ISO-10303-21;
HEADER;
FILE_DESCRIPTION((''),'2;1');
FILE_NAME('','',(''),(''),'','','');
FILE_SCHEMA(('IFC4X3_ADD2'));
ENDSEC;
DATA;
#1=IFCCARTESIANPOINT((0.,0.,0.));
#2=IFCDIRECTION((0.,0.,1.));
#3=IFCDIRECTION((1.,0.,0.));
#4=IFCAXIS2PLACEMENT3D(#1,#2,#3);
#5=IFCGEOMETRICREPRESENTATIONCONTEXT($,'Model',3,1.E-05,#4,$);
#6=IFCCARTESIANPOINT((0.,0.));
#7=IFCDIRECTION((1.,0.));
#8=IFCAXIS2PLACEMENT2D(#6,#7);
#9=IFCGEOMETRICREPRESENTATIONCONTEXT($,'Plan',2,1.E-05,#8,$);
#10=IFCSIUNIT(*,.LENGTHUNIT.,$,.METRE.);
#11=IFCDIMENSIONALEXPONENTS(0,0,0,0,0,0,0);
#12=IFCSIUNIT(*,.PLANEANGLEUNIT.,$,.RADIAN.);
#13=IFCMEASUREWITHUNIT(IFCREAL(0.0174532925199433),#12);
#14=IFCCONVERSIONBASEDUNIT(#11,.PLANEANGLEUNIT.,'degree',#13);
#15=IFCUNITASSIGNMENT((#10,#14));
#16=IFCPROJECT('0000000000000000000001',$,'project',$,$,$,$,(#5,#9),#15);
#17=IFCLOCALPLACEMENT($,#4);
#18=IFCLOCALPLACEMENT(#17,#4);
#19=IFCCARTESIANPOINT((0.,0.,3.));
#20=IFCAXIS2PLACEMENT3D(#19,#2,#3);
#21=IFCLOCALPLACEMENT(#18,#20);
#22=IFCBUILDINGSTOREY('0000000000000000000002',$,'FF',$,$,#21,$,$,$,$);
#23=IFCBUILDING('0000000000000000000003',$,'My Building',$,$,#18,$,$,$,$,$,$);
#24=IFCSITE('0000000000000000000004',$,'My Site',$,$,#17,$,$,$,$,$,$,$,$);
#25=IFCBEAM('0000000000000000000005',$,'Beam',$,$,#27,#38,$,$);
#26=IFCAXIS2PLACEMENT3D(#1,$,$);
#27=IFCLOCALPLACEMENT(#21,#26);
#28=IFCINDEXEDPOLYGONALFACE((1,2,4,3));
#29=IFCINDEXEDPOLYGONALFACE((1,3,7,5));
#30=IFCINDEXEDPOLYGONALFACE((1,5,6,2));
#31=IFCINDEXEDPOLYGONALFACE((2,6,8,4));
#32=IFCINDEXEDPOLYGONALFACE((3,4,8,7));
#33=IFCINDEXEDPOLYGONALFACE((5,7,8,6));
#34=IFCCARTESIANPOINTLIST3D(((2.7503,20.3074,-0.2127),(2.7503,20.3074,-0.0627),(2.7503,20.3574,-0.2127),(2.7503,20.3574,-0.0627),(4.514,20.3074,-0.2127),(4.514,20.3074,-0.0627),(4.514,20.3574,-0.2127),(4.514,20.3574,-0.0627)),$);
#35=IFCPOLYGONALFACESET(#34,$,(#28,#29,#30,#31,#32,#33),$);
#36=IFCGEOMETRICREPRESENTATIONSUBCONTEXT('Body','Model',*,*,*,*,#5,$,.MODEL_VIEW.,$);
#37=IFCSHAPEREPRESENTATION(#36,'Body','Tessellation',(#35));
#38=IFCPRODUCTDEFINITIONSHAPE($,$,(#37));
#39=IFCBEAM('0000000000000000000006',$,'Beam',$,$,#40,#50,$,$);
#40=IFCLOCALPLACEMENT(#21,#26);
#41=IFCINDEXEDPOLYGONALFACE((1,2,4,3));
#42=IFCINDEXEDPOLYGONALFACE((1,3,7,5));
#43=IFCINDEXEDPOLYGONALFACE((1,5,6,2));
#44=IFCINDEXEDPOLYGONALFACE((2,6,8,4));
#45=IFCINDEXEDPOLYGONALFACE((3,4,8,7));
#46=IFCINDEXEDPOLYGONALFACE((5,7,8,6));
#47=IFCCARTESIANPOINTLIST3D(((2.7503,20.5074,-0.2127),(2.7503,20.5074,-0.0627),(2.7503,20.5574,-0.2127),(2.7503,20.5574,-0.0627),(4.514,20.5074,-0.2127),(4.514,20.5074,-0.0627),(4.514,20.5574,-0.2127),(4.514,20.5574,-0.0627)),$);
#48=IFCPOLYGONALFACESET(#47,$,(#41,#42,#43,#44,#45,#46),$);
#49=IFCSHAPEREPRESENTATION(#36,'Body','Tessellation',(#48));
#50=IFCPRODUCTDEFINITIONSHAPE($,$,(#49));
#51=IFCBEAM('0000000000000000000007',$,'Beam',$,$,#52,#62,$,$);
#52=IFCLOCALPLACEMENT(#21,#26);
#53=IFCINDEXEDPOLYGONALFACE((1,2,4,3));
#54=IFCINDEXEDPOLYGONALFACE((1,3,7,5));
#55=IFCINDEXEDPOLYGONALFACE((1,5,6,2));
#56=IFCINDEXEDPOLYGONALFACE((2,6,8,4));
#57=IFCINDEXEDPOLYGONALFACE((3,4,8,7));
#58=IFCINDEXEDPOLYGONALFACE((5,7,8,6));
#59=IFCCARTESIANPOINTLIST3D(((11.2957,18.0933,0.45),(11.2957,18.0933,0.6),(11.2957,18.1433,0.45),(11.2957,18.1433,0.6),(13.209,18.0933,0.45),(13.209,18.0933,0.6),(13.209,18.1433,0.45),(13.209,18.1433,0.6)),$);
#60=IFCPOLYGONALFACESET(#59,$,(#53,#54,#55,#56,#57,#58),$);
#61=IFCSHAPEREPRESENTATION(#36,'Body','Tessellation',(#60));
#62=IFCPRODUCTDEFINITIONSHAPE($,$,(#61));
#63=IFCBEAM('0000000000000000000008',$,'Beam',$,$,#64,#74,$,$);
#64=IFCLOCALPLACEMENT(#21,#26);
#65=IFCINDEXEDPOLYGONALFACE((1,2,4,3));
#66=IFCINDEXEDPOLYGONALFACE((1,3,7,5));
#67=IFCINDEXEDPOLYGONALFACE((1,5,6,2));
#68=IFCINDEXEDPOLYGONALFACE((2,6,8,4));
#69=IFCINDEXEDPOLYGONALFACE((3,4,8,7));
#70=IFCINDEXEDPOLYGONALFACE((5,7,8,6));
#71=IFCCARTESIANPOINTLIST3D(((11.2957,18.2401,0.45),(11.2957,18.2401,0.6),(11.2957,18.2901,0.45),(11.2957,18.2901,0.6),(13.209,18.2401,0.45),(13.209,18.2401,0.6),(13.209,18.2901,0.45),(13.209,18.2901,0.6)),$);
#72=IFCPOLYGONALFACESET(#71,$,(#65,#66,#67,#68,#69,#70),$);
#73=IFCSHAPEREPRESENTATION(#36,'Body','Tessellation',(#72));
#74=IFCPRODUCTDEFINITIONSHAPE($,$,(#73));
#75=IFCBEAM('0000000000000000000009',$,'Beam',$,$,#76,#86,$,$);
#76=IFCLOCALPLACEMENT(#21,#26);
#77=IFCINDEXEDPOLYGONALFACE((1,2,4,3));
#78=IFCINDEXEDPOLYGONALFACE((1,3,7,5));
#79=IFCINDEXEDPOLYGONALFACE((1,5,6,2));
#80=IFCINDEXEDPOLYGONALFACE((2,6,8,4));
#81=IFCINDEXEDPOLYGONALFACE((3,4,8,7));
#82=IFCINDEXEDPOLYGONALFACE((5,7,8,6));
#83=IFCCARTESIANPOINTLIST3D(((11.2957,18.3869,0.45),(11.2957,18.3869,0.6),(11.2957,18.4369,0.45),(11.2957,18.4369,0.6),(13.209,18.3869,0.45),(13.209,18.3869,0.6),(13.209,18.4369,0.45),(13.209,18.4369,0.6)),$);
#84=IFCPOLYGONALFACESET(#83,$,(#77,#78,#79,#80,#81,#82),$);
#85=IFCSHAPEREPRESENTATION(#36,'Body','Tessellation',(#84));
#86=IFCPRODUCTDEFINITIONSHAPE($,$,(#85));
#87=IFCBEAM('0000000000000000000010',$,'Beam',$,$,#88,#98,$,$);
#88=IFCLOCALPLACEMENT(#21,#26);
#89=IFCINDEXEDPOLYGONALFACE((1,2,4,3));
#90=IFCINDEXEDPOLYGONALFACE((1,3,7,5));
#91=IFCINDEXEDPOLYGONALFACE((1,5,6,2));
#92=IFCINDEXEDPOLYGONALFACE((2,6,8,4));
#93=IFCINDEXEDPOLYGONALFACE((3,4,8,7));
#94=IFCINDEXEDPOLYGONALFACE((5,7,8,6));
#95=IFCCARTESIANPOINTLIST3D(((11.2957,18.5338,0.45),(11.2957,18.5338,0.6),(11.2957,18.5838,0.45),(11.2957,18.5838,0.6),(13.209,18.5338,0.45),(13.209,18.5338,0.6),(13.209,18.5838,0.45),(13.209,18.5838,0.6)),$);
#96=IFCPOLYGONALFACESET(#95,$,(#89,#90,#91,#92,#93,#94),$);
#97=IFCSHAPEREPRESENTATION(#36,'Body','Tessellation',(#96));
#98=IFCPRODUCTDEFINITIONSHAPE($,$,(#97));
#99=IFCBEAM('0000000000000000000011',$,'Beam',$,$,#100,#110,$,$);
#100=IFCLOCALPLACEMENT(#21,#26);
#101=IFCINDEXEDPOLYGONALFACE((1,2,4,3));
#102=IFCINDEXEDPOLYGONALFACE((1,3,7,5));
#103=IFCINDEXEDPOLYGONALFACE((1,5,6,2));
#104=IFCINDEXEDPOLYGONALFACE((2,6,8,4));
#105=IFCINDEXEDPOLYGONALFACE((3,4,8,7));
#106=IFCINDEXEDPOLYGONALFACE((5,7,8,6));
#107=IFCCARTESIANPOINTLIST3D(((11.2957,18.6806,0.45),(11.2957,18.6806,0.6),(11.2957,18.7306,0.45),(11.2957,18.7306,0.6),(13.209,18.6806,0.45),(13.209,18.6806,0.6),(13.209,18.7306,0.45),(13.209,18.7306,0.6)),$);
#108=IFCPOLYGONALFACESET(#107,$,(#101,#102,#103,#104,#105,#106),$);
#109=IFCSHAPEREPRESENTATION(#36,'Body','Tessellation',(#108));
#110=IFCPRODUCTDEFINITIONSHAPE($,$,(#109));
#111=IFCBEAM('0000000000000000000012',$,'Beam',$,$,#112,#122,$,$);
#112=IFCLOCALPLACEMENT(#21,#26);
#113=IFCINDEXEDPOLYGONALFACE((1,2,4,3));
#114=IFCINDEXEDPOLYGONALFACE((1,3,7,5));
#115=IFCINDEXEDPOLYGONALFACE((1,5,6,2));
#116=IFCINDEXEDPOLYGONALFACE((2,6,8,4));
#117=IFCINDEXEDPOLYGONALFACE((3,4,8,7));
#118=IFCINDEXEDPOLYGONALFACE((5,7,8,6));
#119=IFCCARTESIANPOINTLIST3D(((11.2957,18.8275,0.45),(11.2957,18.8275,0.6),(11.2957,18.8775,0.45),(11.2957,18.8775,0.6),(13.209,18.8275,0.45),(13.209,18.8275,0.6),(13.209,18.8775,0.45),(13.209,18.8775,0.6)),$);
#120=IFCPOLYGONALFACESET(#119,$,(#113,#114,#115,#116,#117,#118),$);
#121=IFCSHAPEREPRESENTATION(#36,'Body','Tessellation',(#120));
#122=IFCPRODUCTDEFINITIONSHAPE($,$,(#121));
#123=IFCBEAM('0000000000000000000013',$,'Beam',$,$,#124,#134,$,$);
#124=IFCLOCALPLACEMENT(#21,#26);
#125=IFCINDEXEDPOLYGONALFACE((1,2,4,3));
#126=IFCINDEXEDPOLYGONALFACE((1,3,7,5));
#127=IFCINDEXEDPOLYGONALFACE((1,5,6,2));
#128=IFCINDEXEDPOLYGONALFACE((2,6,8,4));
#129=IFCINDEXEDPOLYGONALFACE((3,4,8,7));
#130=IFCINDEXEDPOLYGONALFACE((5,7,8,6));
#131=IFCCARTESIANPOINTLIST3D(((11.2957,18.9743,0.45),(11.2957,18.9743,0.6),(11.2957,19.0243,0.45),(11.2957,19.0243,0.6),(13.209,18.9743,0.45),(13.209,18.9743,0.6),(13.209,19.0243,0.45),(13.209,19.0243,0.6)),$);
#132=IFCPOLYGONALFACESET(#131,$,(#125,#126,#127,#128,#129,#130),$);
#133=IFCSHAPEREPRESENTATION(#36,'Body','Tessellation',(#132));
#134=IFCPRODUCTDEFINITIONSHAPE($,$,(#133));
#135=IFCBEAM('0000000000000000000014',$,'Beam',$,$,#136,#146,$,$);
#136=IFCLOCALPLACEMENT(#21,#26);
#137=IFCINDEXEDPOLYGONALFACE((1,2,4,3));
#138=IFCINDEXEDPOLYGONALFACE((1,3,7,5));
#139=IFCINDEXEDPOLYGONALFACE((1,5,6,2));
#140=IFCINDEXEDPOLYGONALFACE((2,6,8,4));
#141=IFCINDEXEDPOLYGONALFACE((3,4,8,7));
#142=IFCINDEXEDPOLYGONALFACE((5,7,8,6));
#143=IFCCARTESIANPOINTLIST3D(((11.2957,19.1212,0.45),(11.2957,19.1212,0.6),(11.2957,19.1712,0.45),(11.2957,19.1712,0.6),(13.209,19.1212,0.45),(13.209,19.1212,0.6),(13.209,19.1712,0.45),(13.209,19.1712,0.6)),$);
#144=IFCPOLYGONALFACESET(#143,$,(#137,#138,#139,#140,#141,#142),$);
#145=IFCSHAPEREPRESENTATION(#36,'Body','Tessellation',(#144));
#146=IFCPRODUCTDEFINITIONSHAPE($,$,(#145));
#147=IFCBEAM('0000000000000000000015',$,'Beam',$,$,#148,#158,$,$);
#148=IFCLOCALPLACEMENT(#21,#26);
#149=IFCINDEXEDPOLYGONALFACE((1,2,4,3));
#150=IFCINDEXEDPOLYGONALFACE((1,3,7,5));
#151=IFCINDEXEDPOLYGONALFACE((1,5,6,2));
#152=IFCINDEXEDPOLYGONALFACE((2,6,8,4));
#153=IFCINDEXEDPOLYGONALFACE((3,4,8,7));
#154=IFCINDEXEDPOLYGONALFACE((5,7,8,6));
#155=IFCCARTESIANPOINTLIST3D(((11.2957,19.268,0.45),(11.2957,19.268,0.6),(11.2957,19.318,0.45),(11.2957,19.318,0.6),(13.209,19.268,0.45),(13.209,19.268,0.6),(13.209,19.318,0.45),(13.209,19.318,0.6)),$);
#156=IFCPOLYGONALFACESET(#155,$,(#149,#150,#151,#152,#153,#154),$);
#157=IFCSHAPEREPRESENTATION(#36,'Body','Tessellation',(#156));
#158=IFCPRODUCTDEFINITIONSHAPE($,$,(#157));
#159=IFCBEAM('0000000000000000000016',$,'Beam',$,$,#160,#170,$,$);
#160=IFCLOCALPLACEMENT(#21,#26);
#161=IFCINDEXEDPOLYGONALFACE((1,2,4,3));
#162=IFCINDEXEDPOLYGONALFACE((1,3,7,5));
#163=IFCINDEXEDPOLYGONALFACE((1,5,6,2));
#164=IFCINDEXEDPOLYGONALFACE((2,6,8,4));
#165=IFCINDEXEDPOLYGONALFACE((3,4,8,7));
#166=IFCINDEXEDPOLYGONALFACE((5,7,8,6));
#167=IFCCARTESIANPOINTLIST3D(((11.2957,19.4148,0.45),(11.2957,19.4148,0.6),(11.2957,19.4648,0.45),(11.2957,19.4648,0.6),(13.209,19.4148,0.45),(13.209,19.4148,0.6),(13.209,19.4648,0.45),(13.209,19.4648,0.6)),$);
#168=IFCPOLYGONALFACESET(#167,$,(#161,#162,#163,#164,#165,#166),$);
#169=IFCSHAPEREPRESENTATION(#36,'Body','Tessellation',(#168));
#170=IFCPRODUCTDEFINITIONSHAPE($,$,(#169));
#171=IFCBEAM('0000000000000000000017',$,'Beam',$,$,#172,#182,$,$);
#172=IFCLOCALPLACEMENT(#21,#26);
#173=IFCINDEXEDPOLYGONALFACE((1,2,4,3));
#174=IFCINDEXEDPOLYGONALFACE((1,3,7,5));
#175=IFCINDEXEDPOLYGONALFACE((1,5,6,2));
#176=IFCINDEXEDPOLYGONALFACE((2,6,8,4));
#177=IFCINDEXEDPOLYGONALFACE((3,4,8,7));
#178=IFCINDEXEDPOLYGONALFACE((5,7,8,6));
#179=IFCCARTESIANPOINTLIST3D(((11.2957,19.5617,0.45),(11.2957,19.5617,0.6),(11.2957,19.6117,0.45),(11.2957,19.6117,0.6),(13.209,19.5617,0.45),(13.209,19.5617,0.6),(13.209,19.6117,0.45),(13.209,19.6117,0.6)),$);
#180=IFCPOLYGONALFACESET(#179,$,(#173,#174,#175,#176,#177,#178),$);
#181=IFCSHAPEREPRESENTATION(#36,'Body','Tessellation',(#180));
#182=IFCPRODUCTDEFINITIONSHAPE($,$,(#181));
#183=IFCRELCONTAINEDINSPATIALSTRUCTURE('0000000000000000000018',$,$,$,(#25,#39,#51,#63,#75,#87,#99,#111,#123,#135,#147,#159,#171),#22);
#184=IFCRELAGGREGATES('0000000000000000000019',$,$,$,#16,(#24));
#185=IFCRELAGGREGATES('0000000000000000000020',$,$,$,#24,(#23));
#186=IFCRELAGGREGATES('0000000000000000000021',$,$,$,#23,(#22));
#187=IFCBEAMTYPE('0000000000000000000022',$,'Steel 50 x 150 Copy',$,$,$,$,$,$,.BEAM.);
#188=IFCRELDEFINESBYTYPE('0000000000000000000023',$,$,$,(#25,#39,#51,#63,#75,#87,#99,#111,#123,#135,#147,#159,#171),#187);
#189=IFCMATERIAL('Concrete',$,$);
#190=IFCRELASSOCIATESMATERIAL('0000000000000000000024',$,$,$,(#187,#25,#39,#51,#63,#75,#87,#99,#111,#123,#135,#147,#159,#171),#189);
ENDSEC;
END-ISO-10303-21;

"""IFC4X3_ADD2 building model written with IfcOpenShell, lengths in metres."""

from ifc_helpers import new_model, entity, si_unit, converted_unit, frame, origin_with_axes, origin_2d_with_axis, place, context, subcontext, project, spatial, rectangle, extrude, material, material_profile, profile_set, profile_usage, type_object, element, save


model = new_model("IFC4X3_ADD2")

# Units and contexts
model_context = context("Model", 3, precision=1e-05, world=origin_with_axes())
plan_context = context("Plan", 2, precision=1e-05, world=origin_2d_with_axis())
body_context = subcontext(model_context, "Body", "Model", "MODEL_VIEW")
ifc_project = project(units=[si_unit("LENGTHUNIT", "METRE"), converted_unit("PLANEANGLEUNIT", "degree", entity("IfcReal", 0.0174532925199433), si_unit("PLANEANGLEUNIT", "RADIAN"), dimensions=[0, 0, 0, 0, 0, 0, 0])], contexts=[model_context, plan_context])

# Site, building, storey
site_placement = place(None, origin_with_axes())
site = spatial("IfcSite", under=ifc_project, at=site_placement, Name="My Site")
building_placement = place(site_placement, origin_with_axes())
building = spatial("IfcBuilding", under=site, at=building_placement, Name="My Building")
storey_placement = place(building_placement, frame((0.0, 0.0, 3.0), z_axis=(0.0, 0.0, 1.0), x_axis=(1.0, 0.0, 0.0)))
storey = spatial("IfcBuildingStorey", under=building, at=storey_placement, Name="FF")

# Beams
ifc_material = material(Name="Concrete")
ifc_material_profile = material_profile(ifc_material, rectangle(XDim=0.05, YDim=0.15))
ifc_profile_set = profile_set([ifc_material_profile])
beam_type = type_object("IfcBeamType", Name="Steel 50 x 150 Copy", PredefinedType="BEAM", material=ifc_profile_set)
ifc_profile_usage_1 = profile_usage(ifc_profile_set)
beam_1_placement = place(storey_placement, frame((2.7503, 20.3324, -0.1377), z_axis=(1.0, 0.0, 0.0), x_axis=(0.0, 1.0, 0.0)))
element("IfcBeam", 1, at=beam_1_placement, inside=storey, type_object=beam_type, material=ifc_profile_usage_1, Name="Beam", context=body_context, shape_type="SweptSolid", body=[
    extrude(rectangle(XDim=0.05, YDim=0.15), origin_with_axes(), (0.0, 0.0, 1.0), 1.7638),
])
ifc_profile_usage_2 = profile_usage(ifc_profile_set)
beam_2_placement = place(storey_placement, frame((2.7503, 20.5324, -0.1377), z_axis=(1.0, 0.0, 0.0), x_axis=(0.0, 1.0, 0.0)))
element("IfcBeam", 2, at=beam_2_placement, inside=storey, type_object=beam_type, material=ifc_profile_usage_2, Name="Beam", context=body_context, shape_type="SweptSolid", body=[
    extrude(rectangle(XDim=0.05, YDim=0.15), origin_with_axes(), (0.0, 0.0, 1.0), 1.7638),
])
ifc_profile_usage_3 = profile_usage(ifc_profile_set)
beam_3_placement = place(storey_placement, frame((11.2957, 18.1183, 0.525), z_axis=(1.0, 0.0, 0.0), x_axis=(0.0, 1.0, 0.0)))
element("IfcBeam", 3, at=beam_3_placement, inside=storey, type_object=beam_type, material=ifc_profile_usage_3, Name="Beam", context=body_context, shape_type="SweptSolid", body=[
    extrude(rectangle(XDim=0.05, YDim=0.15), origin_with_axes(), (0.0, 0.0, 1.0), 1.9133),
])
ifc_profile_usage_4 = profile_usage(ifc_profile_set)
beam_4_placement = place(storey_placement, frame((11.2957, 18.2651, 0.525), z_axis=(1.0, 0.0, 0.0), x_axis=(0.0, 1.0, 0.0)))
element("IfcBeam", 4, at=beam_4_placement, inside=storey, type_object=beam_type, material=ifc_profile_usage_4, Name="Beam", context=body_context, shape_type="SweptSolid", body=[
    extrude(rectangle(XDim=0.05, YDim=0.15), origin_with_axes(), (0.0, 0.0, 1.0), 1.9133),
])
ifc_profile_usage_5 = profile_usage(ifc_profile_set)
beam_5_placement = place(storey_placement, frame((11.2957, 18.4119, 0.525), z_axis=(1.0, 0.0, 0.0), x_axis=(0.0, 1.0, 0.0)))
element("IfcBeam", 5, at=beam_5_placement, inside=storey, type_object=beam_type, material=ifc_profile_usage_5, Name="Beam", context=body_context, shape_type="SweptSolid", body=[
    extrude(rectangle(XDim=0.05, YDim=0.15), origin_with_axes(), (0.0, 0.0, 1.0), 1.9133),
])
ifc_profile_usage_6 = profile_usage(ifc_profile_set)
beam_6_placement = place(storey_placement, frame((11.2957, 18.5588, 0.525), z_axis=(1.0, 0.0, 0.0), x_axis=(0.0, 1.0, 0.0)))
element("IfcBeam", 6, at=beam_6_placement, inside=storey, type_object=beam_type, material=ifc_profile_usage_6, Name="Beam", context=body_context, shape_type="SweptSolid", body=[
    extrude(rectangle(XDim=0.05, YDim=0.15), origin_with_axes(), (0.0, 0.0, 1.0), 1.9133),
])
ifc_profile_usage_7 = profile_usage(ifc_profile_set)
beam_7_placement = place(storey_placement, frame((11.2957, 18.7056, 0.525), z_axis=(1.0, 0.0, 0.0), x_axis=(0.0, 1.0, 0.0)))
element("IfcBeam", 7, at=beam_7_placement, inside=storey, type_object=beam_type, material=ifc_profile_usage_7, Name="Beam", context=body_context, shape_type="SweptSolid", body=[
    extrude(rectangle(XDim=0.05, YDim=0.15), origin_with_axes(), (0.0, 0.0, 1.0), 1.9133),
])
ifc_profile_usage_8 = profile_usage(ifc_profile_set)
beam_8_placement = place(storey_placement, frame((11.2957, 18.8525, 0.525), z_axis=(1.0, 0.0, 0.0), x_axis=(0.0, 1.0, 0.0)))
element("IfcBeam", 8, at=beam_8_placement, inside=storey, type_object=beam_type, material=ifc_profile_usage_8, Name="Beam", context=body_context, shape_type="SweptSolid", body=[
    extrude(rectangle(XDim=0.05, YDim=0.15), origin_with_axes(), (0.0, 0.0, 1.0), 1.9133),
])
ifc_profile_usage_9 = profile_usage(ifc_profile_set)
beam_9_placement = place(storey_placement, frame((11.2957, 18.9993, 0.525), z_axis=(1.0, 0.0, 0.0), x_axis=(0.0, 1.0, 0.0)))
element("IfcBeam", 9, at=beam_9_placement, inside=storey, type_object=beam_type, material=ifc_profile_usage_9, Name="Beam", context=body_context, shape_type="SweptSolid", body=[
    extrude(rectangle(XDim=0.05, YDim=0.15), origin_with_axes(), (0.0, 0.0, 1.0), 1.9133),
])
ifc_profile_usage_10 = profile_usage(ifc_profile_set)
beam_10_placement = place(storey_placement, frame((11.2957, 19.1462, 0.525), z_axis=(1.0, 0.0, 0.0), x_axis=(0.0, 1.0, 0.0)))
element("IfcBeam", 10, at=beam_10_placement, inside=storey, type_object=beam_type, material=ifc_profile_usage_10, Name="Beam", context=body_context, shape_type="SweptSolid", body=[
    extrude(rectangle(XDim=0.05, YDim=0.15), origin_with_axes(), (0.0, 0.0, 1.0), 1.9133),
])
ifc_profile_usage_11 = profile_usage(ifc_profile_set)
beam_11_placement = place(storey_placement, frame((11.2957, 19.293, 0.525), z_axis=(1.0, 0.0, 0.0), x_axis=(0.0, 1.0, 0.0)))
element("IfcBeam", 11, at=beam_11_placement, inside=storey, type_object=beam_type, material=ifc_profile_usage_11, Name="Beam", context=body_context, shape_type="SweptSolid", body=[
    extrude(rectangle(XDim=0.05, YDim=0.15), origin_with_axes(), (0.0, 0.0, 1.0), 1.9133),
])
ifc_profile_usage_12 = profile_usage(ifc_profile_set)
beam_12_placement = place(storey_placement, frame((11.2957, 19.4398, 0.525), z_axis=(1.0, 0.0, 0.0), x_axis=(0.0, 1.0, 0.0)))
element("IfcBeam", 12, at=beam_12_placement, inside=storey, type_object=beam_type, material=ifc_profile_usage_12, Name="Beam", context=body_context, shape_type="SweptSolid", body=[
    extrude(rectangle(XDim=0.05, YDim=0.15), origin_with_axes(), (0.0, 0.0, 1.0), 1.9133),
])
ifc_profile_usage_13 = profile_usage(ifc_profile_set)
beam_13_placement = place(storey_placement, frame((11.2957, 19.5867, 0.525), z_axis=(1.0, 0.0, 0.0), x_axis=(0.0, 1.0, 0.0)))
element("IfcBeam", 13, at=beam_13_placement, inside=storey, type_object=beam_type, material=ifc_profile_usage_13, Name="Beam", context=body_context, shape_type="SweptSolid", body=[
    extrude(rectangle(XDim=0.05, YDim=0.15), origin_with_axes(), (0.0, 0.0, 1.0), 1.9133),
])

save(model, "model.ifc")
